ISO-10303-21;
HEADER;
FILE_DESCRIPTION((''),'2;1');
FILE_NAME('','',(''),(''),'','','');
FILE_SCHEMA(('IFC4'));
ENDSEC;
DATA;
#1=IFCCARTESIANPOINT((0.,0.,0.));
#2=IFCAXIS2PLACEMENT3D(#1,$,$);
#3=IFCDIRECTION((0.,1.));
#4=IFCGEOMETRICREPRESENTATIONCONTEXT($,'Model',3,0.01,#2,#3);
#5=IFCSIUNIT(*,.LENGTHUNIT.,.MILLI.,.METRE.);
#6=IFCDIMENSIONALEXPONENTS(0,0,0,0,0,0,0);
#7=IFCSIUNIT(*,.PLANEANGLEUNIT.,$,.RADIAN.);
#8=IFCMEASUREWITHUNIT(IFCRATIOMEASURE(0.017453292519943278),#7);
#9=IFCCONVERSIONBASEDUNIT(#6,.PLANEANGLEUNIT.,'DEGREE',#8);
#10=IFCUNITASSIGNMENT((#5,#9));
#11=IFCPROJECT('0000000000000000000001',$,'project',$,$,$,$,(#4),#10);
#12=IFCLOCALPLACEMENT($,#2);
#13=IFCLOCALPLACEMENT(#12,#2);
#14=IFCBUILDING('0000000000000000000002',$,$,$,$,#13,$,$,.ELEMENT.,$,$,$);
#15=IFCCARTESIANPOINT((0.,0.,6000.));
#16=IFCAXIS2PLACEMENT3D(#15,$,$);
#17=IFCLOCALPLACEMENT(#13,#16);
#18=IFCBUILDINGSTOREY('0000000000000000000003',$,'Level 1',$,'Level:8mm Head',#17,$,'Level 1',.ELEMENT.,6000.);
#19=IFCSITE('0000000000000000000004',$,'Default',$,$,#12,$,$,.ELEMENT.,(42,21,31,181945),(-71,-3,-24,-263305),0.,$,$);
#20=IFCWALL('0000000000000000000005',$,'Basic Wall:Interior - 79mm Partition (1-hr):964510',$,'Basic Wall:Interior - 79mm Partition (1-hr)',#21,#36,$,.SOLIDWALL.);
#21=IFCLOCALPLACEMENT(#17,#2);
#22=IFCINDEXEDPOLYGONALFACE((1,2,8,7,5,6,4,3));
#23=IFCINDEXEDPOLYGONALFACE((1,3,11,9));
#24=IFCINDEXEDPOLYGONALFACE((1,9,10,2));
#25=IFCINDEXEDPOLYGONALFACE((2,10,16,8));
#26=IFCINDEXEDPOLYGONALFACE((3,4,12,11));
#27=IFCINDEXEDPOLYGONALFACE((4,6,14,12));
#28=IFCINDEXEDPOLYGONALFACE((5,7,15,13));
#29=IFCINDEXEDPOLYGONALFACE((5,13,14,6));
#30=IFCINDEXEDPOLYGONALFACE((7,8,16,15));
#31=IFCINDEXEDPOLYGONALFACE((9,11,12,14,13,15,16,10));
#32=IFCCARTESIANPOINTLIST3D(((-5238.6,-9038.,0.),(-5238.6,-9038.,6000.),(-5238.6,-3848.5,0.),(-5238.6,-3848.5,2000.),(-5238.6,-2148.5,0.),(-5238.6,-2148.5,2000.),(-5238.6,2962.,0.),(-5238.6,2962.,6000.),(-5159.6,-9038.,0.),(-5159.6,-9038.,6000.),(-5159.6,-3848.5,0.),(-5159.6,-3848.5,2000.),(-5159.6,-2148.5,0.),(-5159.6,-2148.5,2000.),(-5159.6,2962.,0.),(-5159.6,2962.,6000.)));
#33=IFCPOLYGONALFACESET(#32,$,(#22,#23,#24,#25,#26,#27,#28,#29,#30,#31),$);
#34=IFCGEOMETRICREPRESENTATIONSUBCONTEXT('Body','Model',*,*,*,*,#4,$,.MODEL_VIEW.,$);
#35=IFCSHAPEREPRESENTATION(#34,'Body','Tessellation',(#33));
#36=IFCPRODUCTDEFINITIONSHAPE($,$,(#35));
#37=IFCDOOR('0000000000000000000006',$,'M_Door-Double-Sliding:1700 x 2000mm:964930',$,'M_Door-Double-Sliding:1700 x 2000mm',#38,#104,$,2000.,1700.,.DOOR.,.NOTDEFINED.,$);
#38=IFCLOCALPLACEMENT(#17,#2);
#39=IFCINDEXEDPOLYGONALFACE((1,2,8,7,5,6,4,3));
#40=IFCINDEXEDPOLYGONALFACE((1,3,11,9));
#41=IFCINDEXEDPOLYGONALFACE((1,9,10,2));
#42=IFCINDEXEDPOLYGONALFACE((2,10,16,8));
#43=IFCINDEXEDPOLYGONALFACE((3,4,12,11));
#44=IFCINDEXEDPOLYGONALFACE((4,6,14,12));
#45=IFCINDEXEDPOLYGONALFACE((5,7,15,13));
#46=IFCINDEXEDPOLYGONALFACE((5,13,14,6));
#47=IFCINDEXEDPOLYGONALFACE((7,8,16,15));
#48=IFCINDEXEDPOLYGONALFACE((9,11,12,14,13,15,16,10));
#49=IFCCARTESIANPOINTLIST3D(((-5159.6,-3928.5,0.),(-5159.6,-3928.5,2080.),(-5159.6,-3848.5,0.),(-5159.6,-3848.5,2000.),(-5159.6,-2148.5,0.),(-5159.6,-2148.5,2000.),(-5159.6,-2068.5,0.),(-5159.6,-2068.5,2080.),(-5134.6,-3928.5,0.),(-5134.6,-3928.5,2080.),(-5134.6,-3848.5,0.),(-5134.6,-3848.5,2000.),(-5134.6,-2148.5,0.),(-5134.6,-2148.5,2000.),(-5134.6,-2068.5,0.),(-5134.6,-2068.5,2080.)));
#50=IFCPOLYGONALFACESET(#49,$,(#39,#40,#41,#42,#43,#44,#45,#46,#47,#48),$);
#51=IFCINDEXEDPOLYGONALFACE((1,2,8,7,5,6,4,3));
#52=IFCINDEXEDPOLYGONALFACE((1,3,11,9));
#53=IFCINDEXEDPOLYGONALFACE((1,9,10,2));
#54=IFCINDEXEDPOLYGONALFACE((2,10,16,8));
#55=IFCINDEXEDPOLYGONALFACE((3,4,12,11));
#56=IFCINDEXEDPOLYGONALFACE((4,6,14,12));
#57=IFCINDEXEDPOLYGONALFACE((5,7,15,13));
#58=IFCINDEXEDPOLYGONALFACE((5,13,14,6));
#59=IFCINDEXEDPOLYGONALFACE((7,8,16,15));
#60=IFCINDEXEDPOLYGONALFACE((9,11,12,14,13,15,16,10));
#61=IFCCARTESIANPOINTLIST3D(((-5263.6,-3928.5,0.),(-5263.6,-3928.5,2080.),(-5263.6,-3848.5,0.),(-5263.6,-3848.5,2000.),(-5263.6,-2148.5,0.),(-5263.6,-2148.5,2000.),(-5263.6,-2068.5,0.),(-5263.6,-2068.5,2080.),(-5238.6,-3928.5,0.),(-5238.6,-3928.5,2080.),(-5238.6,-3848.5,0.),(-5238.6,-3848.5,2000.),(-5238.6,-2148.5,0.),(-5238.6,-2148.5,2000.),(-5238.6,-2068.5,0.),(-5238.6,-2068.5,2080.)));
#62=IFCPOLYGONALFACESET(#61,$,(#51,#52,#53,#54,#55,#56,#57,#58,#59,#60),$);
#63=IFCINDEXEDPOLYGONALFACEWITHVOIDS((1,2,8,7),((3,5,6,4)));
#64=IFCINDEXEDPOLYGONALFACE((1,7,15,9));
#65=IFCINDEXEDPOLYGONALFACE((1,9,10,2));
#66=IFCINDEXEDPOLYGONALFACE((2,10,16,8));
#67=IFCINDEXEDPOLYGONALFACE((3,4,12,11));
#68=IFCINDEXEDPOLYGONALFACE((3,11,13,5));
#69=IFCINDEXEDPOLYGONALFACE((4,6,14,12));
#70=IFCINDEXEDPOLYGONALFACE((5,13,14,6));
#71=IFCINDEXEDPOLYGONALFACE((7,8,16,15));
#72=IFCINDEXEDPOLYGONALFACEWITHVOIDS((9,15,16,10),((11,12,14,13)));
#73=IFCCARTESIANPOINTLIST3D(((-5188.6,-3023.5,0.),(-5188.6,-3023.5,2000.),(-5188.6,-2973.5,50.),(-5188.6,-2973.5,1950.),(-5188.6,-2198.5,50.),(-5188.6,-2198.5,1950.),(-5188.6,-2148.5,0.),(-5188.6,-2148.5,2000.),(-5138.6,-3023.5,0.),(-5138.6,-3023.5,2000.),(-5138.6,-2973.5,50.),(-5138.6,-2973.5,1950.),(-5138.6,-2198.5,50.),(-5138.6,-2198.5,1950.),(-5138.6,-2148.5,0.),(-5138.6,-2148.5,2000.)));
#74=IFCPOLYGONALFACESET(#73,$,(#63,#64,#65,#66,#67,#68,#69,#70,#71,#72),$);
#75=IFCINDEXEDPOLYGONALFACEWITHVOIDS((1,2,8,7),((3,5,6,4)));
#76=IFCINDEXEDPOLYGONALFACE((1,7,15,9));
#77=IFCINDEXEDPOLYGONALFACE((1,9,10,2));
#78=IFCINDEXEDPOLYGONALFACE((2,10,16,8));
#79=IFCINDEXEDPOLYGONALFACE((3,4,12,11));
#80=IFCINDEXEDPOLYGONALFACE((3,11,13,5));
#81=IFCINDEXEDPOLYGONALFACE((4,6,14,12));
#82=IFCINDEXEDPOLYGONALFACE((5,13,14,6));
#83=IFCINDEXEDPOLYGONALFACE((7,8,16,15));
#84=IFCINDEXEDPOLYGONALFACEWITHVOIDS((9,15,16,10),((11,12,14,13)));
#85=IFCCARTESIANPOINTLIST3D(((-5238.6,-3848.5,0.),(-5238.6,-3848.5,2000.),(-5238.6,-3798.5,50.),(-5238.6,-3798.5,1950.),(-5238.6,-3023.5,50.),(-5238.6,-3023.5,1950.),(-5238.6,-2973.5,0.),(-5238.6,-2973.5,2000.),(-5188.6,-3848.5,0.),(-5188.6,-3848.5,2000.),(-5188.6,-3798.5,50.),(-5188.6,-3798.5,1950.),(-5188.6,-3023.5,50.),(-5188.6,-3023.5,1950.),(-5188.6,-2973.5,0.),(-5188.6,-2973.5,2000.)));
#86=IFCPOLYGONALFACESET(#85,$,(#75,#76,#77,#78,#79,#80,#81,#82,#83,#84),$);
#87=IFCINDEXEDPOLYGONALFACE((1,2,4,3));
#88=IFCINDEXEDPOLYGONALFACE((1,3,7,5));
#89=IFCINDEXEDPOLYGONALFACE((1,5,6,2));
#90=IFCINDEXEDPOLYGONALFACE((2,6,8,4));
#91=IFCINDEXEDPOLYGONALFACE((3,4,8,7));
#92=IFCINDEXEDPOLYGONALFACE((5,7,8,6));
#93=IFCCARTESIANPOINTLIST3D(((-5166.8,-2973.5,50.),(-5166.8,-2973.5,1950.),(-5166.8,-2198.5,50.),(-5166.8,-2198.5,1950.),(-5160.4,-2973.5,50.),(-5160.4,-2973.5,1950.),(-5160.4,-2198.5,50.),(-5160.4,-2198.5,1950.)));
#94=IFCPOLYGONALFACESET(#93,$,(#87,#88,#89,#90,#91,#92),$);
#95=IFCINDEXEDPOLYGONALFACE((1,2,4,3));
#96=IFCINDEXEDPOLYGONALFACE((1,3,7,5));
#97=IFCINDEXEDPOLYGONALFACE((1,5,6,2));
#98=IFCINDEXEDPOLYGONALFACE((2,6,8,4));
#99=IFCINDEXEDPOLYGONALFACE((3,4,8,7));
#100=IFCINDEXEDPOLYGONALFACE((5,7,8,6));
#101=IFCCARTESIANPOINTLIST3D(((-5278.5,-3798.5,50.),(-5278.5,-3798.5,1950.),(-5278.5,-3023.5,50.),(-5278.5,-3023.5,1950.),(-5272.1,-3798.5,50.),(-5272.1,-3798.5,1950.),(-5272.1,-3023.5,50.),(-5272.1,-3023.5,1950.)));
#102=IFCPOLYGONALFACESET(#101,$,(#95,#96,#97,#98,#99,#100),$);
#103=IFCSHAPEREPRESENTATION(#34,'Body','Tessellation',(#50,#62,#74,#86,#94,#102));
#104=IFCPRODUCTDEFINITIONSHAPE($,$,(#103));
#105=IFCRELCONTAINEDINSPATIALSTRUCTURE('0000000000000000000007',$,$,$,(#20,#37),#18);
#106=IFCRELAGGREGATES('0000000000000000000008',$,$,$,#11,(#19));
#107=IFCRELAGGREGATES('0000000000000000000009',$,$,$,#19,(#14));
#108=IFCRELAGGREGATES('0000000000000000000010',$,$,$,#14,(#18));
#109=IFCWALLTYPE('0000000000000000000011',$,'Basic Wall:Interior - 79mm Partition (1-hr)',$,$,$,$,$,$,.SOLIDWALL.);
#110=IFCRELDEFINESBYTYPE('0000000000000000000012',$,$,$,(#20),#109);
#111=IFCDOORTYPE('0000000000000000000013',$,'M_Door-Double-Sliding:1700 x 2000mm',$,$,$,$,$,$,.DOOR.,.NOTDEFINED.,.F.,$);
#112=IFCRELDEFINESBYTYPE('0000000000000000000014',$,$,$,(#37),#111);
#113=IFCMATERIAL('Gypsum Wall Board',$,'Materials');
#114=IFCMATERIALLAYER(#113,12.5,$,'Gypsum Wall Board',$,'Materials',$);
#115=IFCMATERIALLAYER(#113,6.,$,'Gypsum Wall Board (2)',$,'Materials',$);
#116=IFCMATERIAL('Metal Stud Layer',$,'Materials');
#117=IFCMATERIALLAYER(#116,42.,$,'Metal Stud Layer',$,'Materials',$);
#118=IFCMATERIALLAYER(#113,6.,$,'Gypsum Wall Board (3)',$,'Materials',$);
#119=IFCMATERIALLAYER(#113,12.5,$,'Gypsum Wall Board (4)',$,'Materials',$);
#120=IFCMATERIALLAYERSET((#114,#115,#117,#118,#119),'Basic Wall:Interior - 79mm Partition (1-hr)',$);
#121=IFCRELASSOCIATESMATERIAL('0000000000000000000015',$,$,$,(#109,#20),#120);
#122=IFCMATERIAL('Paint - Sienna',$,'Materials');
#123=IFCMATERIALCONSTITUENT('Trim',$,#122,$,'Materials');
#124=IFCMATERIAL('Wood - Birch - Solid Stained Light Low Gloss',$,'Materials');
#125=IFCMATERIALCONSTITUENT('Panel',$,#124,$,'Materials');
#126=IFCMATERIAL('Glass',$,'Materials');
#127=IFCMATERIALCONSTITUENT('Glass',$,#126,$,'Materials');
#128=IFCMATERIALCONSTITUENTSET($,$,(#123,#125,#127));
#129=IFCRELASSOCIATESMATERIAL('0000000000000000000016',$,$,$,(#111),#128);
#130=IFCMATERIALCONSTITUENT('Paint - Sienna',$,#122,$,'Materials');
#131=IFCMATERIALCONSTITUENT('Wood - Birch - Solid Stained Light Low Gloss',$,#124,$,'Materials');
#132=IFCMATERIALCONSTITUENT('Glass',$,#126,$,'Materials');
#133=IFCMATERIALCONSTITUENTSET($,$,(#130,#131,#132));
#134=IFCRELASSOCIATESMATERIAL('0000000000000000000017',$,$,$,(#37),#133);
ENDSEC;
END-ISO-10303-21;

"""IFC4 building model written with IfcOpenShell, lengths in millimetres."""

from ifc_helpers import new_model, entity, si_unit, converted_unit, direction, frame, frame_2d, origin, origin_2d_with_axis, place, context, subcontext, project, spatial, polyline, rectangle, outline, extrude, source, transform, mapped, material, layer, layer_set, layer_usage, constituent, constituent_set, type_object, type_shapes, element, fill, save


model = new_model("IFC4")

# Units and contexts
model_context = context("Model", 3, precision=0.01, world=origin(), true_north=direction((0.0, 1.0)))
body_context = subcontext(model_context, "Body", "Model", "MODEL_VIEW")
ifc_project = project(units=[si_unit("LENGTHUNIT", "METRE", prefix="MILLI"), converted_unit("PLANEANGLEUNIT", "DEGREE", entity("IfcRatioMeasure", 0.017453292519943278), si_unit("PLANEANGLEUNIT", "RADIAN"), dimensions=[0, 0, 0, 0, 0, 0, 0])], contexts=[model_context])

# Site, building, storey
site_placement = place(None, origin())
site = spatial("IfcSite", under=ifc_project, at=site_placement, Name="Default", CompositionType="ELEMENT", RefLatitude=(42, 21, 31, 181945), RefLongitude=(-71, -3, -24, -263305), RefElevation=0.0)
building_placement = place(site_placement, origin())
building = spatial("IfcBuilding", under=site, at=building_placement, CompositionType="ELEMENT")
storey_placement = place(building_placement, frame((0.0, 0.0, 6000.0)))
storey = spatial("IfcBuildingStorey", under=building, at=storey_placement, Name="Level 1", ObjectType="Level:8mm Head", LongName="Level 1", CompositionType="ELEMENT", Elevation=6000.0)

# Shared definitions
ifc_material_1 = material(Name="Gypsum Wall Board", Category="Materials")
ifc_layer_1 = layer(ifc_material_1, 12.5, Name="Gypsum Wall Board", Category="Materials")
ifc_layer_2 = layer(ifc_material_1, 6.0, Name="Gypsum Wall Board (2)", Category="Materials")
ifc_material_2 = material(Name="Metal Stud Layer", Category="Materials")
ifc_layer_3 = layer(ifc_material_2, 42.0, Name="Metal Stud Layer", Category="Materials")
ifc_layer_4 = layer(ifc_material_1, 6.0, Name="Gypsum Wall Board (3)", Category="Materials")
ifc_layer_5 = layer(ifc_material_1, 12.5, Name="Gypsum Wall Board (4)", Category="Materials")
ifc_layer_set_1 = layer_set([ifc_layer_1, ifc_layer_2, ifc_layer_3, ifc_layer_4, ifc_layer_5], Name="Basic Wall:Interior - 79mm Partition (1-hr)")
ifc_layer_usage_1 = layer_usage(ifc_layer_set_1, "AXIS2", "NEGATIVE", 39.5)
wall_type = type_object("IfcWallType", Name="Basic Wall:Interior - 79mm Partition (1-hr)", PredefinedType="SOLIDWALL", material=ifc_layer_set_1)

# Wall, opening, door
ifc_material_3 = material(Name="Paint - Sienna", Category="Materials")
ifc_material_4 = material(Name="Wood - Birch - Solid Stained Light Low Gloss", Category="Materials")
ifc_material_5 = material(Name="Glass", Category="Materials")
ifc_constituent_1 = constituent(ifc_material_3, Name="Trim", Category="Materials")
ifc_constituent_2 = constituent(ifc_material_4, Name="Panel", Category="Materials")
ifc_constituent_3 = constituent(ifc_material_5, Name="Glass", Category="Materials")
ifc_constituent_set_1 = constituent_set(constituents=[ifc_constituent_1, ifc_constituent_2, ifc_constituent_3])
door_type = type_object("IfcDoorType", Name="M_Door-Double-Sliding:1700 x 2000mm", OperationType="NOTDEFINED", ParameterTakesPrecedence=False, PredefinedType="DOOR", material=ifc_constituent_set_1)
shared_shape_1 = source(origin(), body_context, "Body", "SweptSolid", [
    extrude(outline(polyline([(-1020.0, -930.0), (1060.0, -930.0), (1060.0, 930.0), (-1020.0, 930.0), (-1020.0, 850.0), (980.0, 850.0), (980.0, -850.0), (-1020.0, -850.0), (-1020.0, -930.0)])), frame((850.0, -25.0, 1020.0), z_axis=(0.0, 1.0, 0.0), x_axis=(0.0, 0.0, 1.0)), (0.0, 0.0, 1.0), 25.0),
    extrude(outline(polyline([(-930.0, -1020.0), (-850.0, -1020.0), (-850.0, 980.0), (850.0, 980.0), (850.0, -1020.0), (930.0, -1020.0), (930.0, 1060.0), (-930.0, 1060.0), (-930.0, -1020.0)])), frame((850.0, 79.0, 1020.0), z_axis=(0.0, 1.0, 0.0), x_axis=(-1.0, 0.0, 0.0)), (0.0, 0.0, 1.0), 25.0),
    extrude(outline(polyline([(-437.5, -1000.0), (437.5, -1000.0), (437.5, 1000.0), (-437.5, 1000.0), (-437.5, -1000.0)]), holes=[polyline([(-387.5, -950.0), (-387.5, 950.0), (387.5, 950.0), (387.5, -950.0), (-387.5, -950.0)])]), frame((1262.5, -21.0, 1000.0), z_axis=(0.0, 1.0, 0.0), x_axis=(1.0, 0.0, 0.0)), (0.0, 0.0, 1.0), 50.0),
    extrude(outline(polyline([(-1000.0, -437.5), (1000.0, -437.5), (1000.0, 437.5), (-1000.0, 437.5), (-1000.0, -437.5)]), holes=[polyline([(-950.0, -387.5), (-950.0, 387.5), (950.0, 387.5), (950.0, -387.5), (-950.0, -387.5)])]), frame((437.5, 29.0, 1000.0), z_axis=(0.0, 1.0, 0.0), x_axis=(0.0, 0.0, -1.0)), (0.0, 0.0, 1.0), 50.0),
    extrude(rectangle(XDim=6.3, YDim=775.0, at=frame_2d((0.0, 0.0), x_axis=(1.0, 0.0))), frame((1262.5, 4.0, 50.0), z_axis=(0.0, 0.0, 1.0), x_axis=(0.0, -1.0, 0.0)), (0.0, 0.0, 1.0), 1900.0),
    extrude(rectangle(XDim=6.4, YDim=775.0, at=origin_2d_with_axis()), frame((437.5, 115.7, 50.0), z_axis=(0.0, 0.0, 1.0), x_axis=(0.0, 1.0, 0.0)), (0.0, 0.0, 1.0), 1900.0),
])
type_shapes(door_type, [shared_shape_1])
wall_1_placement = place(storey_placement, frame((-5199.1, 2962.0, 0.0), z_axis=(0.0, 0.0, 1.0), x_axis=(0.0, -1.0, 0.0)))
wall_1 = element("IfcWall", 1, at=wall_1_placement, inside=storey, type_object=wall_type, material=ifc_layer_usage_1, Name="Basic Wall:Interior - 79mm Partition (1-hr):964510", ObjectType="Basic Wall:Interior - 79mm Partition (1-hr)", PredefinedType="SOLIDWALL", context=body_context, shape_type="SweptSolid", body=[
    extrude(rectangle(XDim=12000.0, YDim=79.0, at=frame_2d((6000.0, 0.0), x_axis=(1.0, 0.0))), origin(), (0.0, 0.0, 1.0), 6000.0),
])
opening_1_placement = place(wall_1_placement, frame((6810.5, 39.5, 0.0)))
opening_1 = element("IfcOpeningElement", 2, at=opening_1_placement, cuts=wall_1, PredefinedType="OPENING", context=body_context, shape_type="SweptSolid", body=[
    extrude(rectangle(XDim=2000.0, YDim=1700.0, at=frame_2d((1000.0, 850.0), x_axis=(-1.0, 0.0))), frame((0.0, 0.0, 0.0), z_axis=(0.0, -1.0, 0.0), x_axis=(0.0, 0.0, 1.0)), (0.0, 0.0, 1.0), 79.0),
])
ifc_constituent_4 = constituent(ifc_material_3, Name="Paint - Sienna", Category="Materials")
ifc_constituent_5 = constituent(ifc_material_4, Name="Wood - Birch - Solid Stained Light Low Gloss", Category="Materials")
ifc_constituent_6 = constituent(ifc_material_5, Name="Glass", Category="Materials")
ifc_constituent_set_2 = constituent_set(constituents=[ifc_constituent_4, ifc_constituent_5, ifc_constituent_6])
door_1_placement = place(opening_1_placement, frame((0.0, 0.0, 0.0), z_axis=(0.0, 0.0, 1.0), x_axis=(-1.0, 0.0, 0.0)))
door_1 = element("IfcDoor", 3, at=door_1_placement, inside=storey, type_object=door_type, material=ifc_constituent_set_2, Name="M_Door-Double-Sliding:1700 x 2000mm:964930", ObjectType="M_Door-Double-Sliding:1700 x 2000mm", OperationType="NOTDEFINED", OverallHeight=2000.0, OverallWidth=1700.0, PredefinedType="DOOR", context=body_context, shape_type="MappedRepresentation", body=[
    mapped(shared_shape_1, transform((0.0, 0.0, 0.0), scale=1.0)),
])
fill(opening_1, door_1)

save(model, "model.ifc")
